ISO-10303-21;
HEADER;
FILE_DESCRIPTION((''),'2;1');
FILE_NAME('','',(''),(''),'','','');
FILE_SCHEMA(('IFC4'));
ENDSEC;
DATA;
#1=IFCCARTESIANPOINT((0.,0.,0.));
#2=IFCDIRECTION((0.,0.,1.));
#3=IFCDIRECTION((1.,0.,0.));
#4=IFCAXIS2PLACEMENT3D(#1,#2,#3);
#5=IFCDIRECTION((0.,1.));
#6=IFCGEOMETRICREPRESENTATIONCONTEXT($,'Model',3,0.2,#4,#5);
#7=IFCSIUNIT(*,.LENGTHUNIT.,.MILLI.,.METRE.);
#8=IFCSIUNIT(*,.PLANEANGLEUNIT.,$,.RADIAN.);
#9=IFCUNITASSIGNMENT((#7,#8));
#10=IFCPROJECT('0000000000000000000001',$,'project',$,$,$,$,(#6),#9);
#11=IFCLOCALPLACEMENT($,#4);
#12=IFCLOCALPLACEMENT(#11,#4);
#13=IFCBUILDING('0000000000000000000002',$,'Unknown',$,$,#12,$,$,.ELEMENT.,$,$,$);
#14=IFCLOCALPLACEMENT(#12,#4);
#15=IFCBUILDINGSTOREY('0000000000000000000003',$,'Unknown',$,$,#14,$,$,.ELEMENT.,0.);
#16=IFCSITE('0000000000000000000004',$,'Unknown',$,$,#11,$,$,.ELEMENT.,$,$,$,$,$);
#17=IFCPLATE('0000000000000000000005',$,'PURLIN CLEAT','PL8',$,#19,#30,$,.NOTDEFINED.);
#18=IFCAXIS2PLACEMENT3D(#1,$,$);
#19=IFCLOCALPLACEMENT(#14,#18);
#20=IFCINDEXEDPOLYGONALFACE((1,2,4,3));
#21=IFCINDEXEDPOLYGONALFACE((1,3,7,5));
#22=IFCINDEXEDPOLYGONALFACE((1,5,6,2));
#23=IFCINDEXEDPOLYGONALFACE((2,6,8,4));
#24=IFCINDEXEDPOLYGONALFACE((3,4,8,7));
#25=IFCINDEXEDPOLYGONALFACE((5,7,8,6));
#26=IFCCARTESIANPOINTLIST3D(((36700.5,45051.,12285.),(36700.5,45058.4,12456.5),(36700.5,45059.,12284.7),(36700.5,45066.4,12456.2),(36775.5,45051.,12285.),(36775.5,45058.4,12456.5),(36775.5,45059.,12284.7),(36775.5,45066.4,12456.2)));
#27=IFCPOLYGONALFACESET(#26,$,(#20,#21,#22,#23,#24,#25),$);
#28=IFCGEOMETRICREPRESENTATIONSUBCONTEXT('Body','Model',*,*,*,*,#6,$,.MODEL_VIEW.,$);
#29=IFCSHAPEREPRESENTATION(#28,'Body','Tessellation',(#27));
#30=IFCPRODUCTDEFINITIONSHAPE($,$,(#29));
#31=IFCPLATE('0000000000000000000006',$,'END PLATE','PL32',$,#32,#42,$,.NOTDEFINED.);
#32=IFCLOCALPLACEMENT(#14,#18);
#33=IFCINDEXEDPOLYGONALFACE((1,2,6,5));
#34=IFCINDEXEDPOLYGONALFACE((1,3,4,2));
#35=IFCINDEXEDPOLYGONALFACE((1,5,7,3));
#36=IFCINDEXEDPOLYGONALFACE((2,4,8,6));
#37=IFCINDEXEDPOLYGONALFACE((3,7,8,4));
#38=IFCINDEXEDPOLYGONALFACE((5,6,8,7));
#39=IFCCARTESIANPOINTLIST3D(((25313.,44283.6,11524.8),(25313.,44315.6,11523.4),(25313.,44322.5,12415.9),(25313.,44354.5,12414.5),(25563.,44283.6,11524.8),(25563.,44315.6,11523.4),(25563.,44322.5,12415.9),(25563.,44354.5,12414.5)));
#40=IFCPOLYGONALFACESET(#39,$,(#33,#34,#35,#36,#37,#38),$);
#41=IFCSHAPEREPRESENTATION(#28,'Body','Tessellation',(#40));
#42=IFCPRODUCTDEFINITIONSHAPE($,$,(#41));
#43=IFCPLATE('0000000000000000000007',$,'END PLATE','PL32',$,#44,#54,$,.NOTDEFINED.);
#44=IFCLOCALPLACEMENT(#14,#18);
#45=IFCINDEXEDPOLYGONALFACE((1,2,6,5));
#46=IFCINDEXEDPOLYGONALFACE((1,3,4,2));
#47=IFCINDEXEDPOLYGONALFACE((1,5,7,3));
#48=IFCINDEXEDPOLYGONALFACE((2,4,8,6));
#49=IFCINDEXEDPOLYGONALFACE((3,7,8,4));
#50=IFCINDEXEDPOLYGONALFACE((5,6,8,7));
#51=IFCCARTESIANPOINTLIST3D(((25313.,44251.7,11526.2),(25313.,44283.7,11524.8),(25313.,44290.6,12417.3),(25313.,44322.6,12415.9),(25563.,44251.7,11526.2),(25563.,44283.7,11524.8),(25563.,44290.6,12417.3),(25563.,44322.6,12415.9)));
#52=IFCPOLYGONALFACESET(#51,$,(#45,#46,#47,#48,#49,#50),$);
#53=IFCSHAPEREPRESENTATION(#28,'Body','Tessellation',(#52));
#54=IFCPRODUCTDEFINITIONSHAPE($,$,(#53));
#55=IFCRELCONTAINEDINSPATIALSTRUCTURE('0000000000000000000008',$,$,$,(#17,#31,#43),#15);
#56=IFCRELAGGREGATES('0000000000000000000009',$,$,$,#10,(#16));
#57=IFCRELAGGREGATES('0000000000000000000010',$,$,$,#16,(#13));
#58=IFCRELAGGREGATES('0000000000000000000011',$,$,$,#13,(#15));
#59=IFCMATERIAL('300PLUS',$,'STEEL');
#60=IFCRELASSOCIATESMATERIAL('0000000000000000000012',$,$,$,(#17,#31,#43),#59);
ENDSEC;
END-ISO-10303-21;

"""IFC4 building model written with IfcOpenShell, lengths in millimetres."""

from ifc_helpers import new_model, si_unit, direction, frame, origin_with_axes, place, context, subcontext, project, spatial, line, indexed_curve, outline, extrude, material, element, save


model = new_model("IFC4")

# Units and contexts
model_context = context("Model", 3, precision=0.2, world=origin_with_axes(), true_north=direction((0.0, 1.0)))
body_context = subcontext(model_context, "Body", "Model", "MODEL_VIEW")
ifc_project = project(units=[si_unit("LENGTHUNIT", "METRE", prefix="MILLI"), si_unit("PLANEANGLEUNIT", "RADIAN")], contexts=[model_context])

# Site, building, storey
site_placement = place(None, origin_with_axes())
site = spatial("IfcSite", under=ifc_project, at=site_placement, Name="Unknown", CompositionType="ELEMENT")
building_placement = place(site_placement, origin_with_axes())
building = spatial("IfcBuilding", under=site, at=building_placement, Name="Unknown", CompositionType="ELEMENT")
storey_placement = place(building_placement, origin_with_axes())
storey = spatial("IfcBuildingStorey", under=building, at=storey_placement, Name="Unknown", CompositionType="ELEMENT", Elevation=0.0)

# Shared definitions
ifc_material_1 = material(Name="300PLUS", Category="STEEL")

# Plates
plate_placement = place(storey_placement, frame((36700.5, 45055.0, 12284.9), z_axis=(0.0, -0.99907, 0.043109), x_axis=(1.0, 0.0, 0.0)))
element("IfcPlate", 1, at=plate_placement, inside=storey, material=ifc_material_1, Name="PURLIN CLEAT", Description="PL8", PredefinedType="NOTDEFINED", context=body_context, shape_type="SolidModel", body=[
    extrude(outline(indexed_curve([(0.0, 0.0), (75.0, 0.0), (75.0, 171.7), (0.0, 171.7)], segments=[line(1, 2, 3, 4, 1)])), frame((0.0, 0.0, 4.0), z_axis=(0.0, 0.0, 1.0), x_axis=(1.0, 0.0, 0.0)), (0.0, 0.0, -1.0), 8.0),
])
for number, where, z_axis, x_axis, name in (
    (2, (25563.0, 44338.5, 12415.2), (0.0, -0.999049, 0.043612), (-1.0, 0.0, 0.0), "END PLATE"),
    (3, (25563.0, 44306.6, 12416.6), (0.0, -0.999049, 0.043612), (-1.0, 0.0, 0.0), "END PLATE"),
):
    element("IfcPlate", number, at=place(storey_placement, frame(where, z_axis=z_axis, x_axis=x_axis)), inside=storey, material=ifc_material_1, Name=name, Description="PL32", PredefinedType="NOTDEFINED", context=body_context, shape_type="SolidModel", body=[
        extrude(outline(indexed_curve([(0.0, 0.0), (250.0, 0.0), (250.0, 891.9), (0.0, 891.9)], segments=[line(1, 2, 3, 4, 1)])), frame((0.0, 0.0, 16.0), z_axis=(0.0, 0.0, 1.0), x_axis=(1.0, 0.0, 0.0)), (0.0, 0.0, -1.0), 32.0),
    ])

save(model, "model.ifc")
